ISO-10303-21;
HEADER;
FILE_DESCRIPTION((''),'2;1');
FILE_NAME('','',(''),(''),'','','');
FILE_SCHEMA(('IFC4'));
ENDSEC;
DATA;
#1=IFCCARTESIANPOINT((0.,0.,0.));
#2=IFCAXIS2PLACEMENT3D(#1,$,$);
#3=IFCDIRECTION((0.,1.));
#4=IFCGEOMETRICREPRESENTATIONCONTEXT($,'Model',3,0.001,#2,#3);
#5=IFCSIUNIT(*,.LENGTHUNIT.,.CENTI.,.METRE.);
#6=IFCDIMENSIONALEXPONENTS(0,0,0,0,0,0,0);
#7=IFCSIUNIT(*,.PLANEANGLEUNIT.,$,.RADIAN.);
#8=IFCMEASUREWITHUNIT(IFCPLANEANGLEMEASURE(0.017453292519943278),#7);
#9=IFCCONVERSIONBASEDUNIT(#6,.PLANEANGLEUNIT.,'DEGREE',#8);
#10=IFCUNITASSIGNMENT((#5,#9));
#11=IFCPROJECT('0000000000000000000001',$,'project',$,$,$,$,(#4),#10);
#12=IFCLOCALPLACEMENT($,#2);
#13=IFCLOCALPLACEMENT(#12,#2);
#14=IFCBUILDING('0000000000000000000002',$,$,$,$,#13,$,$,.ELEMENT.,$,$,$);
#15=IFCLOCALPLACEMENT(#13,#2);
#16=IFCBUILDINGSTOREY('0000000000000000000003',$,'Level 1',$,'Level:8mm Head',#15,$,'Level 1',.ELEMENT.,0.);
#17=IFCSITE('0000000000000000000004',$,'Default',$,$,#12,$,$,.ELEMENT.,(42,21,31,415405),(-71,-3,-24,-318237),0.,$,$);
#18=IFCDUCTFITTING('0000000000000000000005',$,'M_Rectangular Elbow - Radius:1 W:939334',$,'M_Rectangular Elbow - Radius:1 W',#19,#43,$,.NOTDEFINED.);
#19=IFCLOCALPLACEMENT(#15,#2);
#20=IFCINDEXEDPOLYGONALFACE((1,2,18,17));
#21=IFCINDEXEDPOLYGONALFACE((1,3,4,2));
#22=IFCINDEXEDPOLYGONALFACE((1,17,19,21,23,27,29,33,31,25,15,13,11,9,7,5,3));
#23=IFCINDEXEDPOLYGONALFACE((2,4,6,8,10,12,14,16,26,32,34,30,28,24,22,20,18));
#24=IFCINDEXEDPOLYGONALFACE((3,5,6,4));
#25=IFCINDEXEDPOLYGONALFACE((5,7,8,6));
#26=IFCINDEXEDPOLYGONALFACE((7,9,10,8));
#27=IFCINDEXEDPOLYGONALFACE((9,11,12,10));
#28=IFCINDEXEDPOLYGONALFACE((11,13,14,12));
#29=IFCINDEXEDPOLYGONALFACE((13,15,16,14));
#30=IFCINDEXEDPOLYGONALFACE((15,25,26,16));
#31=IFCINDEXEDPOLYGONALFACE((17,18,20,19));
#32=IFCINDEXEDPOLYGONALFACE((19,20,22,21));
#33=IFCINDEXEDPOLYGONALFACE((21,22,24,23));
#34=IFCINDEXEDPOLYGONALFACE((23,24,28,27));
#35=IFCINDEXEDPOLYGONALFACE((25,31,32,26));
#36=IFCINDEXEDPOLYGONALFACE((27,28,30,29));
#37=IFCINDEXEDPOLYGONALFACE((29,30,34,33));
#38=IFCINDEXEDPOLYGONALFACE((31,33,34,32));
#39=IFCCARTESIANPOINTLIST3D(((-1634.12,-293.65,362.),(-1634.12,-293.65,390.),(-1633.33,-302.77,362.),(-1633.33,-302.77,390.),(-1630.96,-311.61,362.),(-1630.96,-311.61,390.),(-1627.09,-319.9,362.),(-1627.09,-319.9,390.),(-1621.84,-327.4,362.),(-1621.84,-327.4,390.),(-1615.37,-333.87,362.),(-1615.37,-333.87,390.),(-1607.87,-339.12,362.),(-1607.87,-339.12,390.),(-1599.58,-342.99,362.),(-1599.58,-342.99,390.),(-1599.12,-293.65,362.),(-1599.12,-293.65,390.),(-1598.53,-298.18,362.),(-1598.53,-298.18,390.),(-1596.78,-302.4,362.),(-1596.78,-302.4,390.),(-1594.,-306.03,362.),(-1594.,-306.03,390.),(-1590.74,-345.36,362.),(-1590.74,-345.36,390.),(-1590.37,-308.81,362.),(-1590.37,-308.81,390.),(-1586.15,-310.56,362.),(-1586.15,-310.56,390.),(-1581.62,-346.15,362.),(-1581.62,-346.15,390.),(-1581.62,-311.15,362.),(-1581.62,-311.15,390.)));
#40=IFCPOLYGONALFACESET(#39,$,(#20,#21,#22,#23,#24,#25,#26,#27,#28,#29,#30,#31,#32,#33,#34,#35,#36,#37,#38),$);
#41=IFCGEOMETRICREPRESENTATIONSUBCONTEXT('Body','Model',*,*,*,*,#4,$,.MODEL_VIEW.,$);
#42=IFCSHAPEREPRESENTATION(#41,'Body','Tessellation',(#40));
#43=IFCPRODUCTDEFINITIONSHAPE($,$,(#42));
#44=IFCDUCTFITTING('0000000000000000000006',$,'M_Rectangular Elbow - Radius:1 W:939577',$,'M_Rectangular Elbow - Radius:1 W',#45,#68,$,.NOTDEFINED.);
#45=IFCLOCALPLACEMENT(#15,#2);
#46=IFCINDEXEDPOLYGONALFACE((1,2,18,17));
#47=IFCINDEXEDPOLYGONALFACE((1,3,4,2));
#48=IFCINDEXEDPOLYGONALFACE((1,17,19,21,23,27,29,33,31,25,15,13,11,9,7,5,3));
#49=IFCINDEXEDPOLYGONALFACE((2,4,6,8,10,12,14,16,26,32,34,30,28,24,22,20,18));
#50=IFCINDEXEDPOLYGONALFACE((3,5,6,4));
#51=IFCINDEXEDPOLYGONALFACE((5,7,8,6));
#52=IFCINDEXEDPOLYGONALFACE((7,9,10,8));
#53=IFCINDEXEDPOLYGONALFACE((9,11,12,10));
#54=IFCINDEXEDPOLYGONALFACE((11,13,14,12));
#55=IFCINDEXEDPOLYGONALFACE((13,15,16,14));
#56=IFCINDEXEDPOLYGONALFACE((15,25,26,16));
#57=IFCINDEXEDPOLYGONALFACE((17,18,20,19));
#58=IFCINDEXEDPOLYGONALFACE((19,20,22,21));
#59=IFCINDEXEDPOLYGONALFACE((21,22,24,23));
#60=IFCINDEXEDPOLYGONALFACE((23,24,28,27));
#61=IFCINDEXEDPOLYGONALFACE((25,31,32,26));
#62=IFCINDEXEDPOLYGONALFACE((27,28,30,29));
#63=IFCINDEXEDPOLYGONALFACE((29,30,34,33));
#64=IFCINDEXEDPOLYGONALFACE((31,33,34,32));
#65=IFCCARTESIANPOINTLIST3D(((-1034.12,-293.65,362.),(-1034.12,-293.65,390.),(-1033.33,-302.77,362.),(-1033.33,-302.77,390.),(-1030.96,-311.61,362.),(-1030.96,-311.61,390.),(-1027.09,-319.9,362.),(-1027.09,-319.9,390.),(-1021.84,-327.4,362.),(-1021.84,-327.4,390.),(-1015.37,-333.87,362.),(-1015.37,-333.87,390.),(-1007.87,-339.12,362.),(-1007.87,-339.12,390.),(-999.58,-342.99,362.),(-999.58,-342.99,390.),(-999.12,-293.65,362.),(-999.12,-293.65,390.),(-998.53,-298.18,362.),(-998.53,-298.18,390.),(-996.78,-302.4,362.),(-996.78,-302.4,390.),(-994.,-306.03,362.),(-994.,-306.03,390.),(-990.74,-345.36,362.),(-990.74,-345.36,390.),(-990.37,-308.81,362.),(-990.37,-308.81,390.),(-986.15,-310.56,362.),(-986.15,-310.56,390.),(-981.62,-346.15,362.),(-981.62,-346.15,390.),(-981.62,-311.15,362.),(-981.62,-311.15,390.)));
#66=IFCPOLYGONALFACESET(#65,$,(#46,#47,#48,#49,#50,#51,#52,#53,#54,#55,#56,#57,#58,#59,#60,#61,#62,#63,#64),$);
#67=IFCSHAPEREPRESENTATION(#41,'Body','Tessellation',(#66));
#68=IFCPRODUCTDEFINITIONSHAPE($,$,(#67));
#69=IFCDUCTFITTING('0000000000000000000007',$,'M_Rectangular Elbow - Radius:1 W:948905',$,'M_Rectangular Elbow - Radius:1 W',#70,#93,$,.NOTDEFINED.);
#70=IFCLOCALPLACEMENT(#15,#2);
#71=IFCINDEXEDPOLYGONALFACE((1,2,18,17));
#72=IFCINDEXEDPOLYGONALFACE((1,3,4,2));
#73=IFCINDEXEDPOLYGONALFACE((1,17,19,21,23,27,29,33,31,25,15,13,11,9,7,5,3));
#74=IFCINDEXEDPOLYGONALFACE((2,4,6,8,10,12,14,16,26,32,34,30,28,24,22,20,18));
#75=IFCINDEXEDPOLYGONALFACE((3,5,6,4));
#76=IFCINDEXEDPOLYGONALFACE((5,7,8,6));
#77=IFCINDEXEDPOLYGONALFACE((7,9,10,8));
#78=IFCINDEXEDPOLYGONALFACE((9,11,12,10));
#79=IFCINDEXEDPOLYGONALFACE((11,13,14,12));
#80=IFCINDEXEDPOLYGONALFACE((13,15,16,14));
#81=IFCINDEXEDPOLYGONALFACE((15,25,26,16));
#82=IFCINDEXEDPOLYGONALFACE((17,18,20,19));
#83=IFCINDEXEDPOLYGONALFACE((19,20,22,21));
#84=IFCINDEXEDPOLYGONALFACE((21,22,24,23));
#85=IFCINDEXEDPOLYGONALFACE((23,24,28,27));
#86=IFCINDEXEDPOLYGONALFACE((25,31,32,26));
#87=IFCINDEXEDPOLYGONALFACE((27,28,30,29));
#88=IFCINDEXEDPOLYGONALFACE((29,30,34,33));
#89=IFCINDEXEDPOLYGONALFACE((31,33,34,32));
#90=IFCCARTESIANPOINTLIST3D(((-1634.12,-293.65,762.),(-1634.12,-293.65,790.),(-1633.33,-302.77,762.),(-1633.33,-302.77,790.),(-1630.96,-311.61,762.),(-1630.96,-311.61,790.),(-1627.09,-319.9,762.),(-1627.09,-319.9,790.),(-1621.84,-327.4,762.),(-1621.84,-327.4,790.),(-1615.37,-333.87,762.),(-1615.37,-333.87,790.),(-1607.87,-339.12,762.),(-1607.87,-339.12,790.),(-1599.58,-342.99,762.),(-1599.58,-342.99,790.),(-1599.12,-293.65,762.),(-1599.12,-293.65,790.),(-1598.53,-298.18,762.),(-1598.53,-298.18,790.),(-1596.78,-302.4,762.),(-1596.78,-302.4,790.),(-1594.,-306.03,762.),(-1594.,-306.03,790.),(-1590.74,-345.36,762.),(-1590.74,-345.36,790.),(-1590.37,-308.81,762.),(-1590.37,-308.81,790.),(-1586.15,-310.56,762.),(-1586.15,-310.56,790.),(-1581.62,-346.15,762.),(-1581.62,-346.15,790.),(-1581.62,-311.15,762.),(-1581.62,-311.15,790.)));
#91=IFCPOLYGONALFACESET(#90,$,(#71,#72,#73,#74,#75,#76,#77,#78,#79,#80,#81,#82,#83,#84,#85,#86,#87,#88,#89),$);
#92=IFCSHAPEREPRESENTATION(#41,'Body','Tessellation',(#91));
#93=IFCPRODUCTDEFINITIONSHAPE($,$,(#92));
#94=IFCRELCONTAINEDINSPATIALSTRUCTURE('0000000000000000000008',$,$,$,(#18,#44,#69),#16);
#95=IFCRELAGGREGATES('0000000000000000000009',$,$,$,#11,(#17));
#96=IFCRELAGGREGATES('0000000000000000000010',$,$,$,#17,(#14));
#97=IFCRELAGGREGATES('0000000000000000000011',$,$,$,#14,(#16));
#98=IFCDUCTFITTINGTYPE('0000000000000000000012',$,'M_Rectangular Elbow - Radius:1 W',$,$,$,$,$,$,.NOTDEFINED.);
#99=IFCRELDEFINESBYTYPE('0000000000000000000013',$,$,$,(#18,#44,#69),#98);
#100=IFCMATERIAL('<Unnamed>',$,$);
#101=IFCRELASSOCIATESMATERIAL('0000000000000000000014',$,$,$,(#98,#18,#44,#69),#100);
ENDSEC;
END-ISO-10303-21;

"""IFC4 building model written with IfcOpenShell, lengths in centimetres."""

from ifc_helpers import new_model, entity, si_unit, converted_unit, direction, frame, origin, place, context, subcontext, project, spatial, line, arc, indexed_curve, outline, extrude, source, transform, mapped, material, type_object, type_shapes, element, save


model = new_model("IFC4")

# Units and contexts
model_context = context("Model", 3, precision=0.001, world=origin(), true_north=direction((0.0, 1.0)))
body_context = subcontext(model_context, "Body", "Model", "MODEL_VIEW")
ifc_project = project(units=[si_unit("LENGTHUNIT", "METRE", prefix="CENTI"), converted_unit("PLANEANGLEUNIT", "DEGREE", entity("IfcPlaneAngleMeasure", 0.017453292519943278), si_unit("PLANEANGLEUNIT", "RADIAN"), dimensions=[0, 0, 0, 0, 0, 0, 0])], contexts=[model_context])

# Site, building, storey
site_placement = place(None, origin())
site = spatial("IfcSite", under=ifc_project, at=site_placement, Name="Default", CompositionType="ELEMENT", RefLatitude=(42, 21, 31, 415405), RefLongitude=(-71, -3, -24, -318237), RefElevation=0.0)
building_placement = place(site_placement, origin())
building = spatial("IfcBuilding", under=site, at=building_placement, CompositionType="ELEMENT")
storey_placement = place(building_placement, origin())
storey = spatial("IfcBuildingStorey", under=building, at=storey_placement, Name="Level 1", ObjectType="Level:8mm Head", LongName="Level 1", CompositionType="ELEMENT", Elevation=0.0)

# Duct fittings
ifc_material = material(Name="<Unnamed>")
duct_fitting_type_1 = type_object("IfcDuctFittingType", Name="M_Rectangular Elbow - Radius:1 W", PredefinedType="NOTDEFINED", material=ifc_material)
shared_shape_1 = source(origin(), body_context, "Body", "SweptSolid", [
    extrude(outline(indexed_curve([(-35.0, -17.5), (0.0, -17.5), (5.13, -5.13), (17.5, 0.0), (17.5, 35.0), (-19.62, 19.62)], segments=[line(1, 2), arc(2, 3, 4), line(4, 5), arc(5, 6, 1)], self_intersect=False)), frame((-17.5, 17.5, -14.0), z_axis=(0.0, 0.0, 1.0), x_axis=(-1.0, 0.0, 0.0)), (0.0, 0.0, 1.0), 28.0),
])
type_shapes(duct_fitting_type_1, [shared_shape_1])
for number, where, z_axis, x_axis, name in (
    (1, (-1616.62, -328.65, 376.0), (0.0, 0.0, 1.0), (0.0, -1.0, 0.0), "M_Rectangular Elbow - Radius:1 W:939334"),
    (2, (-1016.62, -328.65, 376.0), (0.0, 0.0, 1.0), (0.0, -1.0, 0.0), "M_Rectangular Elbow - Radius:1 W:939577"),
    (3, (-1616.62, -328.65, 776.0), (0.0, 0.0, 1.0), (0.0, -1.0, 0.0), "M_Rectangular Elbow - Radius:1 W:948905"),
):
    element("IfcDuctFitting", number, at=place(storey_placement, frame(where, z_axis=z_axis, x_axis=x_axis)), inside=storey, type_object=duct_fitting_type_1, material=ifc_material, Name=name, ObjectType="M_Rectangular Elbow - Radius:1 W", PredefinedType="NOTDEFINED", context=body_context, shape_type="MappedRepresentation", body=[
        mapped(shared_shape_1, transform((0.0, 0.0, 0.0), scale=1.0)),
    ])

save(model, "model.ifc")
